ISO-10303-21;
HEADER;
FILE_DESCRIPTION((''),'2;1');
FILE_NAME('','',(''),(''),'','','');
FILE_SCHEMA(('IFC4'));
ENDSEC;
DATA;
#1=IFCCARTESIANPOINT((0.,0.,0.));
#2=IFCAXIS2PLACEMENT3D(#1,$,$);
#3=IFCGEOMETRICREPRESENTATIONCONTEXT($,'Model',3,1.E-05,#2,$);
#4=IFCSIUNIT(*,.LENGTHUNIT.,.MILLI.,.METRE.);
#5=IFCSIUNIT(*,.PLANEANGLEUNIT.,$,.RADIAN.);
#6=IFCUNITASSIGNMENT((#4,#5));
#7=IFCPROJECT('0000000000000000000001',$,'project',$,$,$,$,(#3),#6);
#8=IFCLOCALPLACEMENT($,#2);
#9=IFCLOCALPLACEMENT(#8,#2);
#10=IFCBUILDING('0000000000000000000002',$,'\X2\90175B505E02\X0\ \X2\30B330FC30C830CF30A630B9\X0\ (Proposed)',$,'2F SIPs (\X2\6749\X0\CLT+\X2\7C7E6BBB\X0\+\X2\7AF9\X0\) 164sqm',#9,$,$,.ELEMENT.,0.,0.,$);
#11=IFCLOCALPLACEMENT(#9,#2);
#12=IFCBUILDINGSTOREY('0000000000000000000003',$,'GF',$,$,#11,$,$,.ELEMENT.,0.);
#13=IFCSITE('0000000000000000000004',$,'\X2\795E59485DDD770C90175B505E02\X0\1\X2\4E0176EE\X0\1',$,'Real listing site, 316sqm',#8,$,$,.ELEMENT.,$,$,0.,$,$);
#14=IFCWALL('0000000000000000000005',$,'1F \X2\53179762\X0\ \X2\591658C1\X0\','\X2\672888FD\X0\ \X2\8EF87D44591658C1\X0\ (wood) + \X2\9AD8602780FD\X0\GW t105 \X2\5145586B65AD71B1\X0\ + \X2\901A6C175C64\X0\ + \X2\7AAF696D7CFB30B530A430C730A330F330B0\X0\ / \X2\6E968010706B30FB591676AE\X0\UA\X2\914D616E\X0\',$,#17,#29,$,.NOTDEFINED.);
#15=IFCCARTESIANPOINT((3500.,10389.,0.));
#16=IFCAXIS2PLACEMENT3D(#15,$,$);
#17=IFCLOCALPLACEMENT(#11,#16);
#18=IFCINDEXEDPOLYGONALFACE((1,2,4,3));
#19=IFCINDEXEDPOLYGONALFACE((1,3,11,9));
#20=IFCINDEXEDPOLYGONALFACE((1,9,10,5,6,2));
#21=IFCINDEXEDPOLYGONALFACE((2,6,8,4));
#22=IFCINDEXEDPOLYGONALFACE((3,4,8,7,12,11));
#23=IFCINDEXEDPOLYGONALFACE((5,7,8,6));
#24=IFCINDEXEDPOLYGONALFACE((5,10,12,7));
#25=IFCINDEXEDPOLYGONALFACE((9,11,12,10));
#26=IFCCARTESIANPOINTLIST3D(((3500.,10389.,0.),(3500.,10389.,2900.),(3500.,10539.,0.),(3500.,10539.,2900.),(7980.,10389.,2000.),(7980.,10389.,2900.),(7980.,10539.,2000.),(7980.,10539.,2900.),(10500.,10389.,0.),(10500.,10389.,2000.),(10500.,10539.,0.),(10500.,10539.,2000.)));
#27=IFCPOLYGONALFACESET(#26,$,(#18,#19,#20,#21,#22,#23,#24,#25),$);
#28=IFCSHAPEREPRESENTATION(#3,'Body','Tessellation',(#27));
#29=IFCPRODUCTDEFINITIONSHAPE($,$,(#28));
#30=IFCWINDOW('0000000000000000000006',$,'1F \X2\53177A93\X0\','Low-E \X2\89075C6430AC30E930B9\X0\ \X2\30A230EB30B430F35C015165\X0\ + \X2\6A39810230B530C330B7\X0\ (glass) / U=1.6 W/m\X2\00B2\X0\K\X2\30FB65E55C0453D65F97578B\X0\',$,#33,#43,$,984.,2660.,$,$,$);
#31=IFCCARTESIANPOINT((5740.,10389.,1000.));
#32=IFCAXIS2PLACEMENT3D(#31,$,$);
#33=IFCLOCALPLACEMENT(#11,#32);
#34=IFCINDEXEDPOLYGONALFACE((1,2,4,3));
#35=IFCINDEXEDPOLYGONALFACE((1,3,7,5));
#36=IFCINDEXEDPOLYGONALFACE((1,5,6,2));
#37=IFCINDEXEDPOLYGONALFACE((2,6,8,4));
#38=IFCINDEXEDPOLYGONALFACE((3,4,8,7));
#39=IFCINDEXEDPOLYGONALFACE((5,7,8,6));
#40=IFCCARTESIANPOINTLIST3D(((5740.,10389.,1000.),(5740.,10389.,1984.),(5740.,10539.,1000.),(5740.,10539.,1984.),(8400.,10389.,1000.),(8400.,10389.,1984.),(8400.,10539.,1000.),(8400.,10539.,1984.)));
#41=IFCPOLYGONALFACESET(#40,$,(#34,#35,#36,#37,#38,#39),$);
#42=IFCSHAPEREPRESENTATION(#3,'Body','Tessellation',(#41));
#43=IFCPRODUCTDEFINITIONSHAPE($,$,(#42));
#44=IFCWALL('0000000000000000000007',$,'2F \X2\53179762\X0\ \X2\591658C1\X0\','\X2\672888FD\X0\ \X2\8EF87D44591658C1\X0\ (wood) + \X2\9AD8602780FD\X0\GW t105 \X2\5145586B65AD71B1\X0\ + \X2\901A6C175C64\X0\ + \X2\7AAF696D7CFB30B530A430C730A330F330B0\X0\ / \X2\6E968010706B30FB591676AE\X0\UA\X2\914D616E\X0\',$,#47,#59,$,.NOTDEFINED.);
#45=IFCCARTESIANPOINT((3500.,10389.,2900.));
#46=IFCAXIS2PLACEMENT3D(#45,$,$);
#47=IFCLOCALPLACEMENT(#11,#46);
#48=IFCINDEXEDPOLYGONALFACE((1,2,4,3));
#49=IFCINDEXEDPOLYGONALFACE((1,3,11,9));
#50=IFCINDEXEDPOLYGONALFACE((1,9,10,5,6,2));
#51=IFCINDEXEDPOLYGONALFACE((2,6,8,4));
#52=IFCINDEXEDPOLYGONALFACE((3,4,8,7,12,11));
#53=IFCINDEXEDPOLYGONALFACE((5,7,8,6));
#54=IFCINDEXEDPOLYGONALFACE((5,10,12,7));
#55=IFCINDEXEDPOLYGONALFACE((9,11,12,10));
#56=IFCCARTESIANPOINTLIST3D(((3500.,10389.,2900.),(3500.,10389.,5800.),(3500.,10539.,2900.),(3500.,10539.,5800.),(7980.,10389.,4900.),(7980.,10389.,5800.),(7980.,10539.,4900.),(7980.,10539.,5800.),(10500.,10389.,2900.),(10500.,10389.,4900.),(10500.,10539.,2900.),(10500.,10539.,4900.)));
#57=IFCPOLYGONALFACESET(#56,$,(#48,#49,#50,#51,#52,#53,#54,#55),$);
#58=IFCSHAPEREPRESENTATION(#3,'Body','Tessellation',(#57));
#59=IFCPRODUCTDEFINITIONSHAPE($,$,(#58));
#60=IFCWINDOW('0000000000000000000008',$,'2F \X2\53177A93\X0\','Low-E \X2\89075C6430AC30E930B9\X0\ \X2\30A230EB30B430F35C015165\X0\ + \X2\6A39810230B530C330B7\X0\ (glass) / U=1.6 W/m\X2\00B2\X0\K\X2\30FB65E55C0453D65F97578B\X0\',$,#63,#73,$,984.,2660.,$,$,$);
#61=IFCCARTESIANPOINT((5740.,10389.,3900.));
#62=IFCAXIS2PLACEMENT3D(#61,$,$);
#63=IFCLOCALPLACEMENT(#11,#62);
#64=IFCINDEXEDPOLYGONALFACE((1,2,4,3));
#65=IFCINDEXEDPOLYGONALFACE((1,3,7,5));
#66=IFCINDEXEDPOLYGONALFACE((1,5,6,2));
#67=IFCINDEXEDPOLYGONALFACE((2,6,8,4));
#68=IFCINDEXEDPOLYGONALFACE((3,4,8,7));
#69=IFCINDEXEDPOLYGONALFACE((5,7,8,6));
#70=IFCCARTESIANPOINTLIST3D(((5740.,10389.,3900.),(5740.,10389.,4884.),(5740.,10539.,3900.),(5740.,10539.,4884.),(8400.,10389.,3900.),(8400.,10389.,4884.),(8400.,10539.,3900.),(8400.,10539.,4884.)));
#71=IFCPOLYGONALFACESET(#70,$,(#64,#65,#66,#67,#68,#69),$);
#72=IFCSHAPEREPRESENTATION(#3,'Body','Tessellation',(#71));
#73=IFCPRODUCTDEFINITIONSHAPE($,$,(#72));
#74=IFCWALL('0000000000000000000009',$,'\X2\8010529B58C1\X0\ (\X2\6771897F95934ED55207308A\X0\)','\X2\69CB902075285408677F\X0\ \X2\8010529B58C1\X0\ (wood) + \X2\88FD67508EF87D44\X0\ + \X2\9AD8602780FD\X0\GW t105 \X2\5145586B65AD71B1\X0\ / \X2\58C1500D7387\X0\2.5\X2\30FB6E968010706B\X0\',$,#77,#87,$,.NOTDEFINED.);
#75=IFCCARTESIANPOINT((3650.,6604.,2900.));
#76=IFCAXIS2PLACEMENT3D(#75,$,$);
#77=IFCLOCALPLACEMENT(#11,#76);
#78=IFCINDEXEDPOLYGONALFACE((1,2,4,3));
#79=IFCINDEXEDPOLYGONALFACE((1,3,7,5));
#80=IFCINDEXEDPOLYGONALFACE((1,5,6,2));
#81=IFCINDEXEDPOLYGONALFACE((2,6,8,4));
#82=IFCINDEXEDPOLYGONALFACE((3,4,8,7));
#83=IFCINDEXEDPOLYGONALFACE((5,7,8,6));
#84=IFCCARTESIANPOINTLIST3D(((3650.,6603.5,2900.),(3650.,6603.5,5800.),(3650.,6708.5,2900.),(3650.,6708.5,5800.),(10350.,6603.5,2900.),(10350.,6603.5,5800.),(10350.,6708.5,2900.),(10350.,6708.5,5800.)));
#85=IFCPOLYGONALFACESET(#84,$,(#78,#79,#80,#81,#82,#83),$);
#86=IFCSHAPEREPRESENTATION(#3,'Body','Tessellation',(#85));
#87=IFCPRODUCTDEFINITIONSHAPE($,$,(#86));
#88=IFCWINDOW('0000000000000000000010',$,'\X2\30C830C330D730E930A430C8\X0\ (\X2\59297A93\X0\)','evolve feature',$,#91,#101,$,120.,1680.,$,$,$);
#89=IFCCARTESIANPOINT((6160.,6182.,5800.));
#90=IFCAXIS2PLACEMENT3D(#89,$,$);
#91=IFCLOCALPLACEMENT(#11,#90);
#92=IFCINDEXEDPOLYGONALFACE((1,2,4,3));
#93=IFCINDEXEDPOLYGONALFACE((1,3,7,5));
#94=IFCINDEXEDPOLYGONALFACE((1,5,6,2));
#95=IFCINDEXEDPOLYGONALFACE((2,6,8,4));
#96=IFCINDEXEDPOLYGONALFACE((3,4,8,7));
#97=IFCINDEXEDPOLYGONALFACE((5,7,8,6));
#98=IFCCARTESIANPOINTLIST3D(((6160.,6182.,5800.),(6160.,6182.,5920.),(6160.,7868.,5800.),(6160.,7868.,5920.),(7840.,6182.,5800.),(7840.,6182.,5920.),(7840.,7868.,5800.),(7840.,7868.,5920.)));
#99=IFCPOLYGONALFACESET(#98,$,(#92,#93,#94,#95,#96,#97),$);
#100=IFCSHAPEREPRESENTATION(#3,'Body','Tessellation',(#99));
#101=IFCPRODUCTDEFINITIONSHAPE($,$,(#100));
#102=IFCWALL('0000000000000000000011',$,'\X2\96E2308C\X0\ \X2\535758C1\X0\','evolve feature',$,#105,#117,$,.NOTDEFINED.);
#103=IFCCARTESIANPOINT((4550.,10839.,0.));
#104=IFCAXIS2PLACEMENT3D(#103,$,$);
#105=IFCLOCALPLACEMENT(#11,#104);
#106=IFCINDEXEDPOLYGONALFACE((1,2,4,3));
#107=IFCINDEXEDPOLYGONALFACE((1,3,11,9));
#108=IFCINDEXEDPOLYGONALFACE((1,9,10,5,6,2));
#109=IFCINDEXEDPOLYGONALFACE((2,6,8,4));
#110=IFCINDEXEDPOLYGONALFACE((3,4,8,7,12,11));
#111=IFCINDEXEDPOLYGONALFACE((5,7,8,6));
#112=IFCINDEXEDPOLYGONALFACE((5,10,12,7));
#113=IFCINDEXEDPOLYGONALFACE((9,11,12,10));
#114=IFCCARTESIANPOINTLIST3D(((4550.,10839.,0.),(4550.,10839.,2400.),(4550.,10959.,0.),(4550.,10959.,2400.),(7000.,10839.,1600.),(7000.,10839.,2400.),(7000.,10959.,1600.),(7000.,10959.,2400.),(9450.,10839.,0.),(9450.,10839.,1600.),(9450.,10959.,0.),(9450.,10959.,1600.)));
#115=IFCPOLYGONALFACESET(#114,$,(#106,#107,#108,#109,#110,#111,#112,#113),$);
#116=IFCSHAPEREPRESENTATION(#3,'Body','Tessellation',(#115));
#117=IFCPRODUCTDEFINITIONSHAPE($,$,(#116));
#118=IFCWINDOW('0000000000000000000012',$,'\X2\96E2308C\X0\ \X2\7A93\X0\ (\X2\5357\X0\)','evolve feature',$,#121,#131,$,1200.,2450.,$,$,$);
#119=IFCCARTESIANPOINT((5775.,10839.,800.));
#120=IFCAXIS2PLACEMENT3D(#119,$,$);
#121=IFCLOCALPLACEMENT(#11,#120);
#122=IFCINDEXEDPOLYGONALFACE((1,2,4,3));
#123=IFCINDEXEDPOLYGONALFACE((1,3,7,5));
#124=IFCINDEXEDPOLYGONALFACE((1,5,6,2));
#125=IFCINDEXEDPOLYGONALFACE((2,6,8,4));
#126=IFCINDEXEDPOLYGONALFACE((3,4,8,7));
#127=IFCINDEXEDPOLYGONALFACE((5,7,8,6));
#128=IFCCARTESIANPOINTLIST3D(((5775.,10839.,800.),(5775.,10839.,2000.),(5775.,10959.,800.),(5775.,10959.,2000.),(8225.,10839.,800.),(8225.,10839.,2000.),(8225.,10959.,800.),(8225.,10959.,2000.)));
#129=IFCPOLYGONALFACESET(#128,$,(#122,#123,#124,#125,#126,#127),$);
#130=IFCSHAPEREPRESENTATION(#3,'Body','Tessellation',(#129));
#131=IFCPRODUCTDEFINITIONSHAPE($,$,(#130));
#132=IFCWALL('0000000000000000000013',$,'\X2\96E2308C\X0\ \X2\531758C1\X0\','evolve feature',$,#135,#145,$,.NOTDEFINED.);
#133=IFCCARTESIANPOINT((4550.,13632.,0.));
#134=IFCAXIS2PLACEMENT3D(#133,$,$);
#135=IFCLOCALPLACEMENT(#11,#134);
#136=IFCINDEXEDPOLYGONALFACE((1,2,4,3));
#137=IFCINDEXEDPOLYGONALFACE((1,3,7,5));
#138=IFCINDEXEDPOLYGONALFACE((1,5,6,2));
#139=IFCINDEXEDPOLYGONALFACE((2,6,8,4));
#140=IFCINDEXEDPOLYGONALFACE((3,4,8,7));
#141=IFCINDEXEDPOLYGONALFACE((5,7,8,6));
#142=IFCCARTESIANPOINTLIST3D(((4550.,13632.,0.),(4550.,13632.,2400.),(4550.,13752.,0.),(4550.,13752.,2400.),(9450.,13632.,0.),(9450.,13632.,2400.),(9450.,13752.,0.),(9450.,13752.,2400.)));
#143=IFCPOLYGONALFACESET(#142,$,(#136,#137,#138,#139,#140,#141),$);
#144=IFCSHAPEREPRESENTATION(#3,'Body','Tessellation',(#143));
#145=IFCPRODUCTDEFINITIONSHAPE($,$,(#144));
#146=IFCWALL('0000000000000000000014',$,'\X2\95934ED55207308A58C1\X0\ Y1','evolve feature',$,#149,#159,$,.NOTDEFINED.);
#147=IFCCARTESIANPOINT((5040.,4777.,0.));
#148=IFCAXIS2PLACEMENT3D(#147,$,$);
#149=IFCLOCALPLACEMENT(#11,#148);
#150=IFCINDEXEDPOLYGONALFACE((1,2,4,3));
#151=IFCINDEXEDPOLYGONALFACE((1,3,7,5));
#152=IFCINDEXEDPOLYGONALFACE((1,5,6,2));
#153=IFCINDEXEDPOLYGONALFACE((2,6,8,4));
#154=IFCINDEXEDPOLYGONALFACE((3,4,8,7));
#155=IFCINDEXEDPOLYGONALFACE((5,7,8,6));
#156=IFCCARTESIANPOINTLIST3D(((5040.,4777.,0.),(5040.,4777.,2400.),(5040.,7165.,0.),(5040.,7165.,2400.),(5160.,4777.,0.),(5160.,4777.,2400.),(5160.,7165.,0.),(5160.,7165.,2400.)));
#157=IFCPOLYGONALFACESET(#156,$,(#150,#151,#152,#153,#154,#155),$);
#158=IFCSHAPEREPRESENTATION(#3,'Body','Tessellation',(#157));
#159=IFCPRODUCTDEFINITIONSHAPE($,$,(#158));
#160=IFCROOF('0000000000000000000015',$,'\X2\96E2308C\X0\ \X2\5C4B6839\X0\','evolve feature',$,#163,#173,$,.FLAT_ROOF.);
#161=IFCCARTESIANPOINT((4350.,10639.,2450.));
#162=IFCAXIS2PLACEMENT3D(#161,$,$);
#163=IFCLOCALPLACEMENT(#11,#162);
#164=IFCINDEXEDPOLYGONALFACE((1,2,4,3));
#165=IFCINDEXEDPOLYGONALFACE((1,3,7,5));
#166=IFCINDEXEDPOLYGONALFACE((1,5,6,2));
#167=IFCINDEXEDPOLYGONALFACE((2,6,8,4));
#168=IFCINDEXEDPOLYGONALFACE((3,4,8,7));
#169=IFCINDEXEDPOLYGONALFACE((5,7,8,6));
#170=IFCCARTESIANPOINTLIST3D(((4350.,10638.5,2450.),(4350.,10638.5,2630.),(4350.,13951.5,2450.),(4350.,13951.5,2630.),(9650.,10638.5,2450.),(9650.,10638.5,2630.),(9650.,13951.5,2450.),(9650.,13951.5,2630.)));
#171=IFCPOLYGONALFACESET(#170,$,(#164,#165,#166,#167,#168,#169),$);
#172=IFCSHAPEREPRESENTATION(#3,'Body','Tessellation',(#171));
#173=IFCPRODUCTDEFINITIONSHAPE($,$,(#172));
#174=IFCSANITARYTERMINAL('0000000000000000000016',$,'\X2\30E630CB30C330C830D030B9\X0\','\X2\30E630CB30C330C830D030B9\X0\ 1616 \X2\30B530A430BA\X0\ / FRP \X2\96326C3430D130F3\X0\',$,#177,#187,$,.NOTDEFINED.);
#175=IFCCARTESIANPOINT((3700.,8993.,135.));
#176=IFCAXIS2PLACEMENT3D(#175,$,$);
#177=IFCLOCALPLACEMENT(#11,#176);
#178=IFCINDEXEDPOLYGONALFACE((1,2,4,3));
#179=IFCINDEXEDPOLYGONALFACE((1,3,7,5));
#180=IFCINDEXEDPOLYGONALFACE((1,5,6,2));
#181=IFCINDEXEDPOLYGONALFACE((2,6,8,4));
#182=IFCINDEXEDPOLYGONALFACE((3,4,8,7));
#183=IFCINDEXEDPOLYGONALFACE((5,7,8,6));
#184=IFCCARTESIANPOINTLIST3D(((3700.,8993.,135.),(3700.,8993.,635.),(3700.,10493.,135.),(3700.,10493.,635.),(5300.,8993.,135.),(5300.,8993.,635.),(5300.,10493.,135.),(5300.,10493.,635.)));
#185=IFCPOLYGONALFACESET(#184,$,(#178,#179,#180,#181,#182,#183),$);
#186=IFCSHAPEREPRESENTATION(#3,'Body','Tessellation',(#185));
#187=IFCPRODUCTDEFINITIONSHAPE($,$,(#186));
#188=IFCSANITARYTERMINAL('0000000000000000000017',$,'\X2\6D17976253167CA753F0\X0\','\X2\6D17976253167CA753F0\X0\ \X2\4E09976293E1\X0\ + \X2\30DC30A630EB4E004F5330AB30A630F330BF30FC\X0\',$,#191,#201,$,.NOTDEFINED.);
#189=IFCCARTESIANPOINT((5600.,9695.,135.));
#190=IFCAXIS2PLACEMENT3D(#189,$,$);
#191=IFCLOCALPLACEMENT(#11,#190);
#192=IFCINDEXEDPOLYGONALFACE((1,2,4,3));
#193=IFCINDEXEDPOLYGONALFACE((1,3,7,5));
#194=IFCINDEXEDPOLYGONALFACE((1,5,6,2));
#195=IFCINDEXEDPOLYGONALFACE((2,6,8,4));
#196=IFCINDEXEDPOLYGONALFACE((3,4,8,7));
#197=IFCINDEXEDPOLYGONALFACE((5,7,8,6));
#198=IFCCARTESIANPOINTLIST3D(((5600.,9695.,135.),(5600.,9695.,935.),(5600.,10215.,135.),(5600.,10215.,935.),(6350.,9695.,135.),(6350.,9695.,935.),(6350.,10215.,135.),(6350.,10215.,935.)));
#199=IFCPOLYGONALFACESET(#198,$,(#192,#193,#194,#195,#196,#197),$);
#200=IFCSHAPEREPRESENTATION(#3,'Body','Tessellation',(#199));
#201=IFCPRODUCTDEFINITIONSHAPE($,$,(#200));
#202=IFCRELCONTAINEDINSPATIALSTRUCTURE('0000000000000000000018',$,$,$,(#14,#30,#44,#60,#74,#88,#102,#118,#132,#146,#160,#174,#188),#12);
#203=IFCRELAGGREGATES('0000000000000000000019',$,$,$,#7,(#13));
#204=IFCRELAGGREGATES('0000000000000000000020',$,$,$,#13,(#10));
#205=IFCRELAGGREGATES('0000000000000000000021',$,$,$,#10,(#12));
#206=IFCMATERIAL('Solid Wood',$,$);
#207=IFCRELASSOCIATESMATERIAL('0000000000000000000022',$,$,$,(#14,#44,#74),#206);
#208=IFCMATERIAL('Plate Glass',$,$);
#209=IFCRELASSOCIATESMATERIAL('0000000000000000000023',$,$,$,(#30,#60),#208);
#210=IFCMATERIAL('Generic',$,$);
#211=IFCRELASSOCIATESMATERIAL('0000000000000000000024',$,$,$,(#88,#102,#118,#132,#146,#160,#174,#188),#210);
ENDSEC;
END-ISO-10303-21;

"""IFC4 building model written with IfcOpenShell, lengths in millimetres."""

from ifc_helpers import new_model, si_unit, frame, frame_2d, origin, place, context, project, spatial, rectangle, extrude, material, element, fill, save


model = new_model("IFC4")

# Units and contexts
model_context = context("Model", 3, precision=1e-05, world=origin())
ifc_project = project(units=[si_unit("LENGTHUNIT", "METRE", prefix="MILLI"), si_unit("PLANEANGLEUNIT", "RADIAN")], contexts=[model_context])

# Site, building, storey
site_placement = place(None, origin())
site = spatial("IfcSite", under=ifc_project, at=site_placement, Name="神奈川県逗子市1丁目1", ObjectType="Real listing site, 316sqm", CompositionType="ELEMENT", RefElevation=0.0)
building_placement = place(site_placement, origin())
building = spatial("IfcBuilding", under=site, at=building_placement, Name="逗子市 コートハウス (Proposed)", ObjectType="2F SIPs (杉CLT+籾殻+竹) 164sqm", CompositionType="ELEMENT", ElevationOfRefHeight=0.0, ElevationOfTerrain=0.0)
storey_placement = place(building_placement, origin())
storey = spatial("IfcBuildingStorey", under=building, at=storey_placement, Name="GF", CompositionType="ELEMENT", Elevation=0.0)

# Shared definitions
ifc_material_1 = material(Name="Generic")

# Wall, opening, window
ifc_material_2 = material(Name="Solid Wood")
wall_1_placement = place(storey_placement, frame((3500.0, 10389.0, 0.0)))
wall_1 = element("IfcWall", 1, at=wall_1_placement, inside=storey, material=ifc_material_2, Name="1F 北面 外壁", Description="木製 軸組外壁 (wood) + 高性能GW t105 充填断熱 + 通気層 + 窯業系サイディング / 準耐火・外皮UA配慮", PredefinedType="NOTDEFINED", context=model_context, shape_type="SweptSolid", body=[
    extrude(rectangle(XDim=7000.0, YDim=150.0, at=frame_2d((3500.0, 75.0))), frame((3500.0, 10389.0, 0.0)), (0.0, 0.0, 1.0), 2900.0),
])
opening_1_placement = place(storey_placement, frame((5740.0, 10389.0, 1000.0)))
opening_1 = element("IfcOpeningElement", 2, at=opening_1_placement, cuts=wall_1, PredefinedType="NOTDEFINED", context=model_context, shape_type="SweptSolid", body=[
    extrude(rectangle(XDim=2660.0, YDim=150.0, at=frame_2d((1330.0, 75.0))), frame((5740.0, 10389.0, 1000.0)), (0.0, 0.0, 1.0), 984.0),
])
ifc_material_3 = material(Name="Plate Glass")
window_1_placement = place(storey_placement, frame((5740.0, 10389.0, 1000.0)))
window_1 = element("IfcWindow", 3, at=window_1_placement, inside=storey, material=ifc_material_3, Name="1F 北窓", Description="Low-E 複層ガラス アルゴン封入 + 樹脂サッシ (glass) / U=1.6 W/m²K・日射取得型", OverallHeight=984.0, OverallWidth=2660.0, context=model_context, shape_type="SweptSolid", body=[
    extrude(rectangle(XDim=2660.0, YDim=150.0, at=frame_2d((1330.0, 75.0))), frame((5740.0, 10389.0, 1000.0)), (0.0, 0.0, 1.0), 984.0),
])
fill(opening_1, window_1)

# Wall, opening, window
wall_2_placement = place(storey_placement, frame((3500.0, 10389.0, 2900.0)))
wall_2 = element("IfcWall", 4, at=wall_2_placement, inside=storey, material=ifc_material_2, Name="2F 北面 外壁", Description="木製 軸組外壁 (wood) + 高性能GW t105 充填断熱 + 通気層 + 窯業系サイディング / 準耐火・外皮UA配慮", PredefinedType="NOTDEFINED", context=model_context, shape_type="SweptSolid", body=[
    extrude(rectangle(XDim=7000.0, YDim=150.0, at=frame_2d((3500.0, 75.0))), frame((3500.0, 10389.0, 2900.0)), (0.0, 0.0, 1.0), 2900.0),
])
opening_2_placement = place(storey_placement, frame((5740.0, 10389.0, 3900.0)))
opening_2 = element("IfcOpeningElement", 5, at=opening_2_placement, cuts=wall_2, PredefinedType="NOTDEFINED", context=model_context, shape_type="SweptSolid", body=[
    extrude(rectangle(XDim=2660.0, YDim=150.0, at=frame_2d((1330.0, 75.0))), frame((5740.0, 10389.0, 3900.0)), (0.0, 0.0, 1.0), 984.0),
])
window_2_placement = place(storey_placement, frame((5740.0, 10389.0, 3900.0)))
window_2 = element("IfcWindow", 6, at=window_2_placement, inside=storey, material=ifc_material_3, Name="2F 北窓", Description="Low-E 複層ガラス アルゴン封入 + 樹脂サッシ (glass) / U=1.6 W/m²K・日射取得型", OverallHeight=984.0, OverallWidth=2660.0, context=model_context, shape_type="SweptSolid", body=[
    extrude(rectangle(XDim=2660.0, YDim=150.0, at=frame_2d((1330.0, 75.0))), frame((5740.0, 10389.0, 3900.0)), (0.0, 0.0, 1.0), 984.0),
])
fill(opening_2, window_2)

# Wall
wall_3_placement = place(storey_placement, frame((3650.0, 6604.0, 2900.0)))
element("IfcWall", 7, at=wall_3_placement, inside=storey, material=ifc_material_2, Name="耐力壁 (東西間仕切り)", Description="構造用合板 耐力壁 (wood) + 製材軸組 + 高性能GW t105 充填断熱 / 壁倍率2.5・準耐火", PredefinedType="NOTDEFINED", context=model_context, shape_type="SweptSolid", body=[
    extrude(rectangle(XDim=6700.0, YDim=105.0, at=frame_2d((3350.0, 52.0))), frame((3650.0, 6604.0, 2900.0)), (0.0, 0.0, 1.0), 2900.0),
])

# Window
window_3_placement = place(storey_placement, frame((6160.0, 6182.0, 5800.0)))
element("IfcWindow", 8, at=window_3_placement, inside=storey, material=ifc_material_1, Name="トップライト (天窓)", Description="evolve feature", OverallHeight=120.0, OverallWidth=1680.0, context=model_context, shape_type="SweptSolid", body=[
    extrude(rectangle(XDim=1680.0, YDim=1686.0, at=frame_2d((840.0, 843.0))), frame((6160.0, 6182.0, 5800.0)), (0.0, 0.0, 1.0), 120.0),
])

# Wall, opening, window
wall_4_placement = place(storey_placement, frame((4550.0, 10839.0, 0.0)))
wall_4 = element("IfcWall", 9, at=wall_4_placement, inside=storey, material=ifc_material_1, Name="離れ 南壁", Description="evolve feature", PredefinedType="NOTDEFINED", context=model_context, shape_type="SweptSolid", body=[
    extrude(rectangle(XDim=4900.0, YDim=120.0, at=frame_2d((2450.0, 60.0))), frame((4550.0, 10839.0, 0.0)), (0.0, 0.0, 1.0), 2400.0),
])
opening_3_placement = place(storey_placement, frame((5775.0, 10839.0, 800.0)))
opening_3 = element("IfcOpeningElement", 10, at=opening_3_placement, cuts=wall_4, PredefinedType="NOTDEFINED", context=model_context, shape_type="SweptSolid", body=[
    extrude(rectangle(XDim=2450.0, YDim=120.0, at=frame_2d((1225.0, 60.0))), frame((5775.0, 10839.0, 800.0)), (0.0, 0.0, 1.0), 1200.0),
])
window_4_placement = place(storey_placement, frame((5775.0, 10839.0, 800.0)))
window_4 = element("IfcWindow", 11, at=window_4_placement, inside=storey, material=ifc_material_1, Name="離れ 窓 (南)", Description="evolve feature", OverallHeight=1200.0, OverallWidth=2450.0, context=model_context, shape_type="SweptSolid", body=[
    extrude(rectangle(XDim=2450.0, YDim=120.0, at=frame_2d((1225.0, 60.0))), frame((5775.0, 10839.0, 800.0)), (0.0, 0.0, 1.0), 1200.0),
])
fill(opening_3, window_4)

# Walls
wall_5_placement = place(storey_placement, frame((4550.0, 13632.0, 0.0)))
element("IfcWall", 12, at=wall_5_placement, inside=storey, material=ifc_material_1, Name="離れ 北壁", Description="evolve feature", PredefinedType="NOTDEFINED", context=model_context, shape_type="SweptSolid", body=[
    extrude(rectangle(XDim=4900.0, YDim=120.0, at=frame_2d((2450.0, 60.0))), frame((4550.0, 13632.0, 0.0)), (0.0, 0.0, 1.0), 2400.0),
])
wall_6_placement = place(storey_placement, frame((5040.0, 4777.0, 0.0)))
element("IfcWall", 13, at=wall_6_placement, inside=storey, material=ifc_material_1, Name="間仕切り壁 Y1", Description="evolve feature", PredefinedType="NOTDEFINED", context=model_context, shape_type="SweptSolid", body=[
    extrude(rectangle(XDim=120.0, YDim=2388.0, at=frame_2d((60.0, 1194.0))), frame((5040.0, 4777.0, 0.0)), (0.0, 0.0, 1.0), 2400.0),
])

# Roof
roof_placement = place(storey_placement, frame((4350.0, 10639.0, 2450.0)))
element("IfcRoof", 14, at=roof_placement, inside=storey, material=ifc_material_1, Name="離れ 屋根", Description="evolve feature", PredefinedType="FLAT_ROOF", context=model_context, shape_type="SweptSolid", body=[
    extrude(rectangle(XDim=5300.0, YDim=3313.0, at=frame_2d((2650.0, 1656.0))), frame((4350.0, 10639.0, 2450.0)), (0.0, 0.0, 1.0), 180.0),
])

# Sanitary terminals
sanitary_terminal_1_placement = place(storey_placement, frame((3700.0, 8993.0, 135.0)))
element("IfcSanitaryTerminal", 15, at=sanitary_terminal_1_placement, inside=storey, material=ifc_material_1, Name="ユニットバス", Description="ユニットバス 1616 サイズ / FRP 防水パン", PredefinedType="NOTDEFINED", context=model_context, shape_type="SweptSolid", body=[
    extrude(rectangle(XDim=1600.0, YDim=1500.0, at=frame_2d((800.0, 750.0))), frame((3700.0, 8993.0, 135.0)), (0.0, 0.0, 1.0), 500.0),
])
sanitary_terminal_2_placement = place(storey_placement, frame((5600.0, 9695.0, 135.0)))
element("IfcSanitaryTerminal", 16, at=sanitary_terminal_2_placement, inside=storey, material=ifc_material_1, Name="洗面化粧台", Description="洗面化粧台 三面鏡 + ボウル一体カウンター", PredefinedType="NOTDEFINED", context=model_context, shape_type="SweptSolid", body=[
    extrude(rectangle(XDim=750.0, YDim=520.0, at=frame_2d((375.0, 260.0))), frame((5600.0, 9695.0, 135.0)), (0.0, 0.0, 1.0), 800.0),
])

save(model, "model.ifc")
